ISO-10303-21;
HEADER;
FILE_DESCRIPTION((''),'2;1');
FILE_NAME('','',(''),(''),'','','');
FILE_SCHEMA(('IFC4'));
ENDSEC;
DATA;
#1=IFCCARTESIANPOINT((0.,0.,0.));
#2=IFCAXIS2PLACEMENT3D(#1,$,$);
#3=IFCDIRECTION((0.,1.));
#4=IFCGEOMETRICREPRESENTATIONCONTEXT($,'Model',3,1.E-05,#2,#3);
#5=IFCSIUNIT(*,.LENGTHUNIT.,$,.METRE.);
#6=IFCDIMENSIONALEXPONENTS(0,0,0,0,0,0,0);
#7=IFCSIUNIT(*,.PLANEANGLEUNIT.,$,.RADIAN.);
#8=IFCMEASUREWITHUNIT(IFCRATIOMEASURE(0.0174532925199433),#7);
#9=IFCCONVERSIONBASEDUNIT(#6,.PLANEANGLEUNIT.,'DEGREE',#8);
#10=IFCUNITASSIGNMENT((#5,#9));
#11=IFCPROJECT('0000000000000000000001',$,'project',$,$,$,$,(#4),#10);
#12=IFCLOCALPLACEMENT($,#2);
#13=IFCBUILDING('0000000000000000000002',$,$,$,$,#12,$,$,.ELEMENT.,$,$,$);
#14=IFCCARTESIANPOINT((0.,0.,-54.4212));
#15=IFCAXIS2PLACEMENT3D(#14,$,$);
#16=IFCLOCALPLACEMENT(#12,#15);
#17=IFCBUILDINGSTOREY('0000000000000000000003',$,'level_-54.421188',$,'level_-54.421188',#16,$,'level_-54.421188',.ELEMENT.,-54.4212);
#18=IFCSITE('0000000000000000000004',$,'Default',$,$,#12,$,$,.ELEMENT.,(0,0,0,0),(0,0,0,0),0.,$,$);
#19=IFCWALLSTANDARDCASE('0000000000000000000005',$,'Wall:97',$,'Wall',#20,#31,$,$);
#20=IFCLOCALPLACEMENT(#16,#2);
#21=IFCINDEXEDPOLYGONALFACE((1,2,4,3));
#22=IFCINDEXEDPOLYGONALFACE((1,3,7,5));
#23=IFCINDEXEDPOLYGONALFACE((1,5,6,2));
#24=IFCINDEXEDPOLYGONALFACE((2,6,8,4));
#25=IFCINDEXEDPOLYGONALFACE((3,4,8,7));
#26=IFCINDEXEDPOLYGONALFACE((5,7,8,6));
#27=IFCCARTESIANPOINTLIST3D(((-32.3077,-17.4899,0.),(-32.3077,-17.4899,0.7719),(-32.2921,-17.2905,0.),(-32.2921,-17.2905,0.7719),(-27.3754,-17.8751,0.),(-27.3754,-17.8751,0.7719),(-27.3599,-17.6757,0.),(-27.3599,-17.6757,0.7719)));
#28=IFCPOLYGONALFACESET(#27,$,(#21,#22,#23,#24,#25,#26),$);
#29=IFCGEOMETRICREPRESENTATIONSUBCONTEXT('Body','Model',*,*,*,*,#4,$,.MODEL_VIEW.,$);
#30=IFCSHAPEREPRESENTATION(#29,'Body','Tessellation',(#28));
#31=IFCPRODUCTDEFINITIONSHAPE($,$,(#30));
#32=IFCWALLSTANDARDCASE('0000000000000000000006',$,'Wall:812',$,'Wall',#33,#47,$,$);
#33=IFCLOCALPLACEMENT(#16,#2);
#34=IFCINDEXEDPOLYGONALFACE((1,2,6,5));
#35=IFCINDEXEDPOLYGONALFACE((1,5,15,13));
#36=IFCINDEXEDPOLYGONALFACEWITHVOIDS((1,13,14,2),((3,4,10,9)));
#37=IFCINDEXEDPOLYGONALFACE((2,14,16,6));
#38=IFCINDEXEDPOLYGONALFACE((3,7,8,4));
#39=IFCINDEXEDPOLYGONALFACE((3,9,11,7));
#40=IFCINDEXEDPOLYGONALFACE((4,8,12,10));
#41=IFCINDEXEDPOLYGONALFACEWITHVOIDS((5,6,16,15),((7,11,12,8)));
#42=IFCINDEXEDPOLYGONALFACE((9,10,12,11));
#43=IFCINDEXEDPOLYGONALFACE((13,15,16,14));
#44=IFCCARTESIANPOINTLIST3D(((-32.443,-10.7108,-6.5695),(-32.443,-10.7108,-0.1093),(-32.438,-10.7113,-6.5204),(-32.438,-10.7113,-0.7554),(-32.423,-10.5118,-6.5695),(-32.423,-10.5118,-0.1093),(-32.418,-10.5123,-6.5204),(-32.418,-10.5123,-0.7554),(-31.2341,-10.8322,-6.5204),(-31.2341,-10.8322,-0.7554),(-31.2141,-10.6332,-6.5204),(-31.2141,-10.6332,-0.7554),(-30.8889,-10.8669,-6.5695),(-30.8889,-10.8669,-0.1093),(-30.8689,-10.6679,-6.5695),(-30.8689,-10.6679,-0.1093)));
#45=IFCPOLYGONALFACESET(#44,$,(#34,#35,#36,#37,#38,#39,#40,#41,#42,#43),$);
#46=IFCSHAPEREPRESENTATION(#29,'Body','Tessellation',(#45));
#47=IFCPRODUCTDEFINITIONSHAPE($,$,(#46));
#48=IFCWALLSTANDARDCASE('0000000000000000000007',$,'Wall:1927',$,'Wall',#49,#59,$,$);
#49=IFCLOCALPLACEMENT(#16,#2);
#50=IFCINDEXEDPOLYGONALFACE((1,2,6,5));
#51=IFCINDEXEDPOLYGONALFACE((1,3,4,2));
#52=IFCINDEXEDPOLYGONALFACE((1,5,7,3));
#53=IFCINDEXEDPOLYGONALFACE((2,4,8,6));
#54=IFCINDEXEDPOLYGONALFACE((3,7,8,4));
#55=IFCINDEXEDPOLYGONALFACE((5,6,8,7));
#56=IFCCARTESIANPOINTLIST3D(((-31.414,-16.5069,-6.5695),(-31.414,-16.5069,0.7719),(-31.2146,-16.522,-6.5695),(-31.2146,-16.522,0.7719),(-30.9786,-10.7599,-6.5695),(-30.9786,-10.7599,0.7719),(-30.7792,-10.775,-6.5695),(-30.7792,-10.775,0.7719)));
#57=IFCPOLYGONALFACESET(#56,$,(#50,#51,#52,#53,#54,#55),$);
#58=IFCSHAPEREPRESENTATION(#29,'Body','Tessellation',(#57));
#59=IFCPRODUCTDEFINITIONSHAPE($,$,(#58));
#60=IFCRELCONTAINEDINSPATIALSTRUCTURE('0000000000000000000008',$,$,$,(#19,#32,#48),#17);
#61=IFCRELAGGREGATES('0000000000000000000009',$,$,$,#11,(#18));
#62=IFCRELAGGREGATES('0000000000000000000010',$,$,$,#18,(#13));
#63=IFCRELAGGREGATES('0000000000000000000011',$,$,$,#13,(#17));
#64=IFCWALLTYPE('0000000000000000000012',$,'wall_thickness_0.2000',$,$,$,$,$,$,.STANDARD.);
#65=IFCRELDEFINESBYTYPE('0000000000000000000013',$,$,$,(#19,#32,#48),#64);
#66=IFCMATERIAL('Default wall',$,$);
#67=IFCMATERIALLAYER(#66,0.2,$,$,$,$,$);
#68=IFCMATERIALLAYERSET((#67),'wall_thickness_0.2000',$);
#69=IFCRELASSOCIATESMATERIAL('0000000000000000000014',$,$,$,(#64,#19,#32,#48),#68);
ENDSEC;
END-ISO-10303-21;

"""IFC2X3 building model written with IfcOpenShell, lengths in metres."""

from ifc_helpers import new_model, entity, si_unit, converted_unit, direction, frame, frame_2d, origin, place, context, subcontext, project, spatial, polyline, rectangle, outline, extrude, material, layer, layer_set, layer_usage, type_object, element, save


model = new_model("IFC2X3")

# Units and contexts
model_context = context("Model", 3, precision=1e-05, world=origin(), true_north=direction((0.0, 1.0)))
body_context = subcontext(model_context, "Body", "Model", "MODEL_VIEW")
ifc_project = project(units=[si_unit("LENGTHUNIT", "METRE"), converted_unit("PLANEANGLEUNIT", "DEGREE", entity("IfcRatioMeasure", 0.0174532925199433), si_unit("PLANEANGLEUNIT", "RADIAN"), dimensions=[0, 0, 0, 0, 0, 0, 0])], contexts=[model_context])

# Site, building, storey
placement_1 = place(None, origin())
site = spatial("IfcSite", under=ifc_project, at=placement_1, Name="Default", CompositionType="ELEMENT", RefLatitude=(0, 0, 0, 0), RefLongitude=(0, 0, 0, 0), RefElevation=0.0)
building = spatial("IfcBuilding", under=site, at=placement_1, CompositionType="ELEMENT")
storey_placement = place(placement_1, frame((0.0, 0.0, -54.4212)))
storey = spatial("IfcBuildingStorey", under=building, at=storey_placement, Name="level_-54.421188", ObjectType="level_-54.421188", LongName="level_-54.421188", CompositionType="ELEMENT", Elevation=-54.4212)

# Wall
ifc_material = material(Name="Default wall")
ifc_layer = layer(ifc_material, 0.2)
ifc_layer_set = layer_set([ifc_layer], Name="wall_thickness_0.2000")
ifc_layer_usage = layer_usage(ifc_layer_set, "AXIS2", "POSITIVE", -0.1)
wall_type = type_object("IfcWallType", Name="wall_thickness_0.2000", PredefinedType="STANDARD", material=ifc_layer_set)
wall_1_placement = place(storey_placement, frame((-32.2999, -17.3902, 0.0), z_axis=(0.0, 0.0, 1.0), x_axis=(0.996964, -0.077869, 0.0)))
element("IfcWallStandardCase", 1, at=wall_1_placement, inside=storey, type_object=wall_type, material=ifc_layer_usage, Name="Wall:97", ObjectType="Wall", context=body_context, shape_type="SweptSolid", body=[
    extrude(outline(polyline([(4.9472, -0.1), (4.9472, 0.1), (0.0, 0.1), (0.0, -0.1), (4.9472, -0.1)])), origin(), (0.0, 0.0, 1.0), 0.7719),
])

# Wall, opening
placement_2 = place(placement_1, frame((0.0, 0.0, -60.9907)))
wall_2_placement = place(placement_2, frame((-30.8789, -10.7674, 0.0), z_axis=(0.0, 0.0, 1.0), x_axis=(-0.994991, 0.099967, 0.0)))
wall_2 = element("IfcWallStandardCase", 2, at=wall_2_placement, inside=storey, type_object=wall_type, material=ifc_layer_usage, Name="Wall:812", ObjectType="Wall", context=body_context, shape_type="SweptSolid", body=[
    extrude(outline(polyline([(1.562, -0.1), (1.562, 0.1), (0.0, 0.1), (0.0, -0.1), (1.562, -0.1)])), origin(), (0.0, 0.0, 1.0), 6.4602),
])
opening_placement = place(wall_2_placement, frame((0.347, -0.1, 0.0491)))
element("IfcOpeningElement", 3, at=opening_placement, cuts=wall_2, ObjectType="Opening", context=body_context, shape_type="SweptSolid", body=[
    extrude(rectangle(XDim=1.21, YDim=5.765, at=frame_2d((2.8825, 0.605), x_axis=(0.0, 1.0))), frame((0.0, 0.0, 0.0), z_axis=(0.0, 1.0, 0.0), x_axis=(0.0, 0.0, 1.0)), (0.0, 0.0, 1.0), 0.2),
])

# Wall
placement_3 = place(placement_1, frame((0.0, 0.0, -60.9907)))
wall_3_placement = place(placement_3, frame((-30.8789, -10.7674, 0.0), z_axis=(0.0, 0.0, 1.0), x_axis=(-0.075552, -0.997142, 0.0)))
element("IfcWallStandardCase", 4, at=wall_3_placement, inside=storey, type_object=wall_type, material=ifc_layer_usage, Name="Wall:1927", ObjectType="Wall", context=body_context, shape_type="SweptSolid", body=[
    extrude(outline(polyline([(5.7635, -0.1), (5.7635, 0.1), (0.0, 0.1), (0.0, -0.1), (5.7635, -0.1)])), origin(), (0.0, 0.0, 1.0), 7.3414),
])

save(model, "model.ifc")
